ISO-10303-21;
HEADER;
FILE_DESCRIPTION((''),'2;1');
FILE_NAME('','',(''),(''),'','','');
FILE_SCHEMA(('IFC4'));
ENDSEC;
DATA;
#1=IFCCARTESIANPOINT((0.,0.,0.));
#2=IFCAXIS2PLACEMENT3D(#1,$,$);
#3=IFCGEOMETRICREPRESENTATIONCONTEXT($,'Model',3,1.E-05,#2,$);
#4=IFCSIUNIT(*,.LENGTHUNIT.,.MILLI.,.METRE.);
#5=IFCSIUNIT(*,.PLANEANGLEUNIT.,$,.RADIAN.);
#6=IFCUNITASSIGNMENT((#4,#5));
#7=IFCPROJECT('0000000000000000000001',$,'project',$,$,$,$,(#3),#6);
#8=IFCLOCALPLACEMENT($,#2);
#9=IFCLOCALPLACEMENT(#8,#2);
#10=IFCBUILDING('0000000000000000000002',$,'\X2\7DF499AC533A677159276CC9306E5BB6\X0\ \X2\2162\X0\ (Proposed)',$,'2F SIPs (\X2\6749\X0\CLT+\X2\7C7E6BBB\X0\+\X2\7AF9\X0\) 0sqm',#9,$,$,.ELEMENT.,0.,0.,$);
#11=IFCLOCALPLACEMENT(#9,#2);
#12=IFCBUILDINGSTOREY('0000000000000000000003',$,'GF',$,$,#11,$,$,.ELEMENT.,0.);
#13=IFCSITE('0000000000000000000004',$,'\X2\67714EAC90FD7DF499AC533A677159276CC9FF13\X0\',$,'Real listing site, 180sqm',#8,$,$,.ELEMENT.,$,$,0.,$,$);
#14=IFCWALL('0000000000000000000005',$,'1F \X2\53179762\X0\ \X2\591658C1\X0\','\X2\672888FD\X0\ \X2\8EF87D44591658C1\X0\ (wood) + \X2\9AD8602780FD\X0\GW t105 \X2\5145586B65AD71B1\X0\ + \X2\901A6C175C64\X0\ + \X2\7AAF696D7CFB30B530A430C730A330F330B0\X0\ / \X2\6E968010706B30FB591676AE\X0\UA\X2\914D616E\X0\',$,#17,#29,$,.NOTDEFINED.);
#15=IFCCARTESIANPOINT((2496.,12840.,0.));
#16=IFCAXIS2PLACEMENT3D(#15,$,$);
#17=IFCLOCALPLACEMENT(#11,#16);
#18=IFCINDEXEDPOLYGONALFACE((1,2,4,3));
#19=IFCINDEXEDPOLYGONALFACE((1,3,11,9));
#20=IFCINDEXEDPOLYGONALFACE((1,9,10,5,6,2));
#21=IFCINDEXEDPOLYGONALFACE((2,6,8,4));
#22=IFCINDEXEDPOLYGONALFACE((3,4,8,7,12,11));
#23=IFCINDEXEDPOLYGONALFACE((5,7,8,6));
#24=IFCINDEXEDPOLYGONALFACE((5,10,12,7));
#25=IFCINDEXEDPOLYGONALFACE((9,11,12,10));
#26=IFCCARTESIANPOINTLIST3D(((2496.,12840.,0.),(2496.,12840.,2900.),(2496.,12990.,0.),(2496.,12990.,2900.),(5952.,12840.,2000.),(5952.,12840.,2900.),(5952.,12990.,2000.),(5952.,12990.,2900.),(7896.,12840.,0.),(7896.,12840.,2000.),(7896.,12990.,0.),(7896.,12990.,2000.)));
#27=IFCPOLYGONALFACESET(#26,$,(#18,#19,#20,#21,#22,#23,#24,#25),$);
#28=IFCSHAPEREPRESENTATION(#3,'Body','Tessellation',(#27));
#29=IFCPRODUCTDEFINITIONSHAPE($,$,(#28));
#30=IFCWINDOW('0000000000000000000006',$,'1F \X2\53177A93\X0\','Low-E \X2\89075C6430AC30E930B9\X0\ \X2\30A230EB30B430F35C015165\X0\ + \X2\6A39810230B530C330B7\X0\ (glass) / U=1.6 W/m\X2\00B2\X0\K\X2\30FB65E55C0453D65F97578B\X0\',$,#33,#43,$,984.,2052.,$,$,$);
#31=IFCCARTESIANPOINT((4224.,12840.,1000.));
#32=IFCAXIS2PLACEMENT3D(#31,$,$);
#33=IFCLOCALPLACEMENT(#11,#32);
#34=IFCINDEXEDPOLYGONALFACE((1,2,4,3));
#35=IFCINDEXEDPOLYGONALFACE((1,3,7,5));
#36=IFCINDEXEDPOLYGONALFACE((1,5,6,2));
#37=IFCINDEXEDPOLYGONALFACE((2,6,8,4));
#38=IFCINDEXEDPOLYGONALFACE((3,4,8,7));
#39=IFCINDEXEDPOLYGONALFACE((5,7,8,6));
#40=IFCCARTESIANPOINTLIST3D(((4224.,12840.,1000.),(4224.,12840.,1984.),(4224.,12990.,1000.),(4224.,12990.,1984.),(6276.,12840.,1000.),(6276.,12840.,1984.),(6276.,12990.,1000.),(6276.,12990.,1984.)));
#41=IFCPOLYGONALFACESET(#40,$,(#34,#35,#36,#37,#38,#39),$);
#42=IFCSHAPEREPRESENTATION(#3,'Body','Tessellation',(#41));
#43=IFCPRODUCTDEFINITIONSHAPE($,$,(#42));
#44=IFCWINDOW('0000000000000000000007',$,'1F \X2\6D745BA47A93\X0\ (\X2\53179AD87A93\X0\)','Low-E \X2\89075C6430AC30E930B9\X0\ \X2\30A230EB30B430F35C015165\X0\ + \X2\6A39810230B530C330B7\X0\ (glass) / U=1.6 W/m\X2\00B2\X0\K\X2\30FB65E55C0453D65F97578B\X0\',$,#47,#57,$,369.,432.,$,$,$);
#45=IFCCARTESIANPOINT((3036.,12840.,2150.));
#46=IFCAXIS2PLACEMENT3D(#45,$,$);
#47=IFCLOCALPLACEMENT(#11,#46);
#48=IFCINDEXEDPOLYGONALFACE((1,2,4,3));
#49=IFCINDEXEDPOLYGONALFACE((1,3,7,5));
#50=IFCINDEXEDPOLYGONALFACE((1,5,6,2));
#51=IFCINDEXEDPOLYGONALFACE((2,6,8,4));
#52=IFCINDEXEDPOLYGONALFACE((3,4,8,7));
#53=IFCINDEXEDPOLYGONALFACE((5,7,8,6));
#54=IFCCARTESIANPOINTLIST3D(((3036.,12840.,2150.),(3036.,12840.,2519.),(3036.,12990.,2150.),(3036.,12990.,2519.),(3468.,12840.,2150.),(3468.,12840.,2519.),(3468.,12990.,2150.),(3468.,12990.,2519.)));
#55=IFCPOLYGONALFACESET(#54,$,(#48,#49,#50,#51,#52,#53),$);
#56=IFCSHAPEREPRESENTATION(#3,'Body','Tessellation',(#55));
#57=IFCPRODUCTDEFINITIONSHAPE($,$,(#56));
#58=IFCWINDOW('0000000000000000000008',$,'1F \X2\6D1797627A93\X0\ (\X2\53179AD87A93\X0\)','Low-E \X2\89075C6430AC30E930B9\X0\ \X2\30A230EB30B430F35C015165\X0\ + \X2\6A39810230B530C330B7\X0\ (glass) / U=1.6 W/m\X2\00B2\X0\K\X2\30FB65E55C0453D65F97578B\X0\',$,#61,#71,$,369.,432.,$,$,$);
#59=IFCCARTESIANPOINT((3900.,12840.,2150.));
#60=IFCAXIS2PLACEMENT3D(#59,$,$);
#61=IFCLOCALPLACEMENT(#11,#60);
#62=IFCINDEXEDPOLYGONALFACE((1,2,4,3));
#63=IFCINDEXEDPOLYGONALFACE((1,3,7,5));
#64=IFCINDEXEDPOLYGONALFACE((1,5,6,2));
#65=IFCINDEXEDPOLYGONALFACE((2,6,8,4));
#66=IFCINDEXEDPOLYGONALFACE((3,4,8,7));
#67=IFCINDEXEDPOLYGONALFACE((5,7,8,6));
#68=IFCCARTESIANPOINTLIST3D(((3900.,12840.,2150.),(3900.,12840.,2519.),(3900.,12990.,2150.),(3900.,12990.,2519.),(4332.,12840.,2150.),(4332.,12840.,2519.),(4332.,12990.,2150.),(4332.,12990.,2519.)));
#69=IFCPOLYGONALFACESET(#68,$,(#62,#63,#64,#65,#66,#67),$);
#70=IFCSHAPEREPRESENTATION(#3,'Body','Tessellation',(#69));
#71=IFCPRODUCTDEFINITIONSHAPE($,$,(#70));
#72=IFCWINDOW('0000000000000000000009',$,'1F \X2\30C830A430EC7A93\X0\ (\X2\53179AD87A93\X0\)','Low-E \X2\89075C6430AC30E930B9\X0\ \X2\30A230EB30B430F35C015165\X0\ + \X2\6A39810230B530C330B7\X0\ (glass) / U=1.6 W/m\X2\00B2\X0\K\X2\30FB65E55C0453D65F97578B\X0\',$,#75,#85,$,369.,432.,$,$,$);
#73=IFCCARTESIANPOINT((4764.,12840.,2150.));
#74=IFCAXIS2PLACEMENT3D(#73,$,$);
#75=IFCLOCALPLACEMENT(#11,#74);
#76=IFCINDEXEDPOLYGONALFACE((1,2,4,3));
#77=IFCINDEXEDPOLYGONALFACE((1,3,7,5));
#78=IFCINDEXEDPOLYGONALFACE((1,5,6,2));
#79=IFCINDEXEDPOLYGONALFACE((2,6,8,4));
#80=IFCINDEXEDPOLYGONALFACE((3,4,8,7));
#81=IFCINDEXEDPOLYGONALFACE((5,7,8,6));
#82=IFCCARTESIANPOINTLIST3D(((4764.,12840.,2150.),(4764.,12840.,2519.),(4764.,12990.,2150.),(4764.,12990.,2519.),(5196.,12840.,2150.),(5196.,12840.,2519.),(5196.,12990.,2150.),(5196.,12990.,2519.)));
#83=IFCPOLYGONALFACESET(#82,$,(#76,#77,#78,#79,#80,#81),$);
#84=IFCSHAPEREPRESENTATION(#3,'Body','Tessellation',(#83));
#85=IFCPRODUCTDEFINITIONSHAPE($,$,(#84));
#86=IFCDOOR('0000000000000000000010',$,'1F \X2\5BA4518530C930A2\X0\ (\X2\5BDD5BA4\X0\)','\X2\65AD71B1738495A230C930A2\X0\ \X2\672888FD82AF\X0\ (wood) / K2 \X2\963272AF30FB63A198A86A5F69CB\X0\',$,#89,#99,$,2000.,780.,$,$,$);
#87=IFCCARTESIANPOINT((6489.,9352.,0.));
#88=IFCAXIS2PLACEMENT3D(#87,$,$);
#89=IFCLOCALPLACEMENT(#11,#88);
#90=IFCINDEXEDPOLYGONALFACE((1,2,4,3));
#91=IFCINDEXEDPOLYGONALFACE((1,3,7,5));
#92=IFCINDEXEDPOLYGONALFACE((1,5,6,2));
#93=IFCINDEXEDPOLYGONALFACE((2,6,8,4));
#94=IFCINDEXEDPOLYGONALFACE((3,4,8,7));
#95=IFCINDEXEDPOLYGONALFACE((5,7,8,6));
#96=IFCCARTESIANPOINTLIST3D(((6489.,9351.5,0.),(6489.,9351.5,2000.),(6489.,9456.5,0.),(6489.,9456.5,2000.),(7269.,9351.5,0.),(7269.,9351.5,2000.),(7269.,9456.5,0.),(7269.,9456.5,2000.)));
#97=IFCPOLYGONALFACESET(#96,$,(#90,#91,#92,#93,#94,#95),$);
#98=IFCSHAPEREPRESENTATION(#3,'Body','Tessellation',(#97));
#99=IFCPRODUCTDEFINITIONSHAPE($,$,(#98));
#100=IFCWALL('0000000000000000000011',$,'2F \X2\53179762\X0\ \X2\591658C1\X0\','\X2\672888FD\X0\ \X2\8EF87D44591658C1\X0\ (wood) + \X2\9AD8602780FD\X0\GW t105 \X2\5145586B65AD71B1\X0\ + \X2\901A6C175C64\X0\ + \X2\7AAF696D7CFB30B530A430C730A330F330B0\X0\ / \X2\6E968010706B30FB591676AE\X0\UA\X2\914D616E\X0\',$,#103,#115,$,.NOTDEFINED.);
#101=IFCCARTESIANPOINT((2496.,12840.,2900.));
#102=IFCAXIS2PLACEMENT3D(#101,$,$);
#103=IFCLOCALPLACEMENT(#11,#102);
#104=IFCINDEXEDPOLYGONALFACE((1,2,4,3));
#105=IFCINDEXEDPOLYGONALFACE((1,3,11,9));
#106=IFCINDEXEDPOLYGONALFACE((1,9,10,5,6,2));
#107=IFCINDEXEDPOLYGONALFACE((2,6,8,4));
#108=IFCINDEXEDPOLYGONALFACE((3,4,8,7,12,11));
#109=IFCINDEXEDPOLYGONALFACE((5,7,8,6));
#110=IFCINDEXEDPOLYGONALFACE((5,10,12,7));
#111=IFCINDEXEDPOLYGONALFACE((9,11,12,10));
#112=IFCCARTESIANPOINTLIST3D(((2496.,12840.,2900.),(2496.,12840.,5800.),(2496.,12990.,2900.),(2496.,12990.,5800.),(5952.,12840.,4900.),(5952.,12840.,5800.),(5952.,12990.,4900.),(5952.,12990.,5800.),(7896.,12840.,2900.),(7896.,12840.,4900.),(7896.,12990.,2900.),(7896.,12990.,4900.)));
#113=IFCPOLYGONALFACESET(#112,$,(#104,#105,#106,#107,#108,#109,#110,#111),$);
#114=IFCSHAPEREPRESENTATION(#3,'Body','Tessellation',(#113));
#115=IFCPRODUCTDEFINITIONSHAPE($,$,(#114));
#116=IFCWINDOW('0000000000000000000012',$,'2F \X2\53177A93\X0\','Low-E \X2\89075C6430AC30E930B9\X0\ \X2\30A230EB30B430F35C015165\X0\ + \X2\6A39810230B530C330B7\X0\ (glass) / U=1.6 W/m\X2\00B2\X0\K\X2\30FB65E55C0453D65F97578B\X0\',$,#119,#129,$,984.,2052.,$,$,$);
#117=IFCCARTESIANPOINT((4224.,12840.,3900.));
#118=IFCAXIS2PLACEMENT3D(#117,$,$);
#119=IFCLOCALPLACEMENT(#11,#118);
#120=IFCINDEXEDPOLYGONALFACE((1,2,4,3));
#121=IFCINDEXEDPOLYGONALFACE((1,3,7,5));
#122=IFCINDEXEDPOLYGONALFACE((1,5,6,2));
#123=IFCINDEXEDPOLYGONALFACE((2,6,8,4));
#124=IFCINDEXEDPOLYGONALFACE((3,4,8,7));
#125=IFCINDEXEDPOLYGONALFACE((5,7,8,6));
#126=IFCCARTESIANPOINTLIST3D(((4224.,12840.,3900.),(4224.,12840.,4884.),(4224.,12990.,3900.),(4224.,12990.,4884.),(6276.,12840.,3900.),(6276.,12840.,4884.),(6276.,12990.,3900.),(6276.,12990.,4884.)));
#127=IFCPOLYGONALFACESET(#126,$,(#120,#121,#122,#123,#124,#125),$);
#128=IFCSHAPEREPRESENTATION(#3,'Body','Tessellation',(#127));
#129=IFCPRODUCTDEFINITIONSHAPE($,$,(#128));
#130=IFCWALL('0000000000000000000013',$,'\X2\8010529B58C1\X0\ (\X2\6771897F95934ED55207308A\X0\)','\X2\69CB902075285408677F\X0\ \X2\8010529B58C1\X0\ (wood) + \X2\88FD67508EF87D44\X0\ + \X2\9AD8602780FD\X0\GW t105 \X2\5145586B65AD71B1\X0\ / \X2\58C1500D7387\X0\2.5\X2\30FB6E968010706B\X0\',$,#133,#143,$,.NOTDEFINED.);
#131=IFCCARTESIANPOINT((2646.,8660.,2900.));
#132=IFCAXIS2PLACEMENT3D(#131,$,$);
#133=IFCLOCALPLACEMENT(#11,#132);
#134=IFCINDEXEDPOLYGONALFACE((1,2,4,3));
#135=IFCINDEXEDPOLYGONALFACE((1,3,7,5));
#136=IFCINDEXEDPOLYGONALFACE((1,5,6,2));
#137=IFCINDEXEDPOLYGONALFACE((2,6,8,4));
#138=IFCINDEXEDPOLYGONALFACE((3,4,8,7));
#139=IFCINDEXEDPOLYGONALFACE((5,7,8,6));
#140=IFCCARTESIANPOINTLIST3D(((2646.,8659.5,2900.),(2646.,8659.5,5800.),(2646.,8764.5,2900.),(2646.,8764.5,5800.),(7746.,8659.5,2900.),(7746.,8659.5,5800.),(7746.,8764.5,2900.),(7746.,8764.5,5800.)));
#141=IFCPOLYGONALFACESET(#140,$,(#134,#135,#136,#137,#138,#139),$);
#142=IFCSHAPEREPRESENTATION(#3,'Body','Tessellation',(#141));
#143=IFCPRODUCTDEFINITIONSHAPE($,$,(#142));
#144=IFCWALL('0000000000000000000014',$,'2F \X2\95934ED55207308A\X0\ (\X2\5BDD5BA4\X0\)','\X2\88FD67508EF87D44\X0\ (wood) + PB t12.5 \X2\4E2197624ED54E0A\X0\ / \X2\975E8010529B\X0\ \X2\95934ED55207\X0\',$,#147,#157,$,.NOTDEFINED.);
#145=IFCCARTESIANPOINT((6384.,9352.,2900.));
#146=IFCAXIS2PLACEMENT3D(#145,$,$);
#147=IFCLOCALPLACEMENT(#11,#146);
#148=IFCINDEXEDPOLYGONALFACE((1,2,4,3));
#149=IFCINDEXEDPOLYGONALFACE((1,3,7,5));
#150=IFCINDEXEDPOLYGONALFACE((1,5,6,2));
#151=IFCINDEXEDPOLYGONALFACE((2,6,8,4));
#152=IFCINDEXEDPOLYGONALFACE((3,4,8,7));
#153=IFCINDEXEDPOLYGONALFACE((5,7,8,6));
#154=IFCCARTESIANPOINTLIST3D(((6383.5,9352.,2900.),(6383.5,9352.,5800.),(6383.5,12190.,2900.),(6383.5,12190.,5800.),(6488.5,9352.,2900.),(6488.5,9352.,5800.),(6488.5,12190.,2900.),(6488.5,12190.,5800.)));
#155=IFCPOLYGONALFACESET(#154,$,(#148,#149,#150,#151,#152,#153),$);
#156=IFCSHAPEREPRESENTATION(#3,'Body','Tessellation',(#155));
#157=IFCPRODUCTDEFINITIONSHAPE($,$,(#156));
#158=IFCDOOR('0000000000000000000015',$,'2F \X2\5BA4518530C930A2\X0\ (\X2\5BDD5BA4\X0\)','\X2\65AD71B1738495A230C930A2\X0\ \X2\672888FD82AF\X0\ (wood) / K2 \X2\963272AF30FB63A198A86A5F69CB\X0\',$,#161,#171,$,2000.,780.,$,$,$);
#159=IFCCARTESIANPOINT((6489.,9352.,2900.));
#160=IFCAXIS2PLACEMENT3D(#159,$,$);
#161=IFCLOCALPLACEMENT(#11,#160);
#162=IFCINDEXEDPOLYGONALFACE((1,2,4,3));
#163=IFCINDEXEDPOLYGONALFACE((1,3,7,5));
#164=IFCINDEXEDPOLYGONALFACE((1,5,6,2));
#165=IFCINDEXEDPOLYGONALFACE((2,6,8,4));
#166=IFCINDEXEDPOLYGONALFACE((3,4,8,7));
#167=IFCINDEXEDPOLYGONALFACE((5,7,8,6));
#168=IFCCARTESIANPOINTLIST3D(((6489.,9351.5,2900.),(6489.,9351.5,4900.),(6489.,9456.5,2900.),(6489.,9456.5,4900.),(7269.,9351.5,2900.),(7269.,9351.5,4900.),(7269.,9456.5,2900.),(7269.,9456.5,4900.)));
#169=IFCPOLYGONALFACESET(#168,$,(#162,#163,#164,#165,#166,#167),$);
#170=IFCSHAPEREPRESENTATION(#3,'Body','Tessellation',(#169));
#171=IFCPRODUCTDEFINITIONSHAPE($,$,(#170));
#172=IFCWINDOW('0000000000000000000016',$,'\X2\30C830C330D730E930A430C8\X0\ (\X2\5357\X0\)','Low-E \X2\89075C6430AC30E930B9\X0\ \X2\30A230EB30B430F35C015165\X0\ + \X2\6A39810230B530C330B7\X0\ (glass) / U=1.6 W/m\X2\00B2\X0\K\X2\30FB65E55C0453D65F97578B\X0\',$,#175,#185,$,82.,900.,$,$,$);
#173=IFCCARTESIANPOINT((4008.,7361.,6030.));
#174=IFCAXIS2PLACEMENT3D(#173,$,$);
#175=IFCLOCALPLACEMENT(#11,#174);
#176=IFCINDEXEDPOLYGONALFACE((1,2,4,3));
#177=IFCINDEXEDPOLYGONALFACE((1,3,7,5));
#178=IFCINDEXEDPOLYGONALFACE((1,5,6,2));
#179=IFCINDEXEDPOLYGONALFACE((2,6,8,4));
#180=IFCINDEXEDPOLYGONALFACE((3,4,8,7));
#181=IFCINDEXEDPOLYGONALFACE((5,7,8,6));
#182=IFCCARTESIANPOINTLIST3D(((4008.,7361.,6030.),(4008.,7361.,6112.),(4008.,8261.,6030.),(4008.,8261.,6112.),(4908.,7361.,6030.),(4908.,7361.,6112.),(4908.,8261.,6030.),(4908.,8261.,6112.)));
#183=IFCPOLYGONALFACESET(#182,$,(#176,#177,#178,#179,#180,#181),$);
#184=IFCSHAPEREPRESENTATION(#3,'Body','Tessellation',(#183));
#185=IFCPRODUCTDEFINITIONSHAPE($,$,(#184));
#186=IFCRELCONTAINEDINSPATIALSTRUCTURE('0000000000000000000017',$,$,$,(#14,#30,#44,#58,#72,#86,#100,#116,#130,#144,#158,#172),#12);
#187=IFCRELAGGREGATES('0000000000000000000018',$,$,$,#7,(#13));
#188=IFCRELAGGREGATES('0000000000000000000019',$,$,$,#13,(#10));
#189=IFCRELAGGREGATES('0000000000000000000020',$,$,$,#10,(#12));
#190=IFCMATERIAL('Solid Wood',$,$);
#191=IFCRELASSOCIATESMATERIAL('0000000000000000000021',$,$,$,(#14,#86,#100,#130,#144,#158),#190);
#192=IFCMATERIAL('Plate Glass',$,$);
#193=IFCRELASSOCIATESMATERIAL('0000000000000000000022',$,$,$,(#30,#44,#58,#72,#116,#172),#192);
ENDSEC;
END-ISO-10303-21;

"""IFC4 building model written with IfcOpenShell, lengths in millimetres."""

from ifc_helpers import new_model, si_unit, frame, frame_2d, origin, place, context, project, spatial, rectangle, extrude, material, element, fill, save


model = new_model("IFC4")

# Units and contexts
model_context = context("Model", 3, precision=1e-05, world=origin())
ifc_project = project(units=[si_unit("LENGTHUNIT", "METRE", prefix="MILLI"), si_unit("PLANEANGLEUNIT", "RADIAN")], contexts=[model_context])

# Site, building, storey
site_placement = place(None, origin())
site = spatial("IfcSite", under=ifc_project, at=site_placement, Name="東京都練馬区東大泉３", ObjectType="Real listing site, 180sqm", CompositionType="ELEMENT", RefElevation=0.0)
building_placement = place(site_placement, origin())
building = spatial("IfcBuilding", under=site, at=building_placement, Name="練馬区東大泉の家 Ⅲ (Proposed)", ObjectType="2F SIPs (杉CLT+籾殻+竹) 0sqm", CompositionType="ELEMENT", ElevationOfRefHeight=0.0, ElevationOfTerrain=0.0)
storey_placement = place(building_placement, origin())
storey = spatial("IfcBuildingStorey", under=building, at=storey_placement, Name="GF", CompositionType="ELEMENT", Elevation=0.0)

# Wall, openings, windows
ifc_material_1 = material(Name="Solid Wood")
wall_1_placement = place(storey_placement, frame((2496.0, 12840.0, 0.0)))
wall_1 = element("IfcWall", 1, at=wall_1_placement, inside=storey, material=ifc_material_1, Name="1F 北面 外壁", Description="木製 軸組外壁 (wood) + 高性能GW t105 充填断熱 + 通気層 + 窯業系サイディング / 準耐火・外皮UA配慮", PredefinedType="NOTDEFINED", context=model_context, shape_type="SweptSolid", body=[
    extrude(rectangle(XDim=5400.0, YDim=150.0, at=frame_2d((2700.0, 75.0))), frame((2496.0, 12840.0, 0.0)), (0.0, 0.0, 1.0), 2900.0),
])
opening_1_placement = place(storey_placement, frame((4224.0, 12840.0, 1000.0)))
opening_1 = element("IfcOpeningElement", 2, at=opening_1_placement, cuts=wall_1, PredefinedType="NOTDEFINED", context=model_context, shape_type="SweptSolid", body=[
    extrude(rectangle(XDim=2052.0, YDim=150.0, at=frame_2d((1026.0, 75.0))), frame((4224.0, 12840.0, 1000.0)), (0.0, 0.0, 1.0), 984.0),
])
opening_2_placement = place(storey_placement, frame((3036.0, 12840.0, 2150.0)))
opening_2 = element("IfcOpeningElement", 3, at=opening_2_placement, cuts=wall_1, PredefinedType="NOTDEFINED", context=model_context, shape_type="SweptSolid", body=[
    extrude(rectangle(XDim=432.0, YDim=150.0, at=frame_2d((216.0, 75.0))), frame((3036.0, 12840.0, 2150.0)), (0.0, 0.0, 1.0), 369.0),
])
opening_3_placement = place(storey_placement, frame((3900.0, 12840.0, 2150.0)))
opening_3 = element("IfcOpeningElement", 4, at=opening_3_placement, cuts=wall_1, PredefinedType="NOTDEFINED", context=model_context, shape_type="SweptSolid", body=[
    extrude(rectangle(XDim=432.0, YDim=150.0, at=frame_2d((216.0, 75.0))), frame((3900.0, 12840.0, 2150.0)), (0.0, 0.0, 1.0), 369.0),
])
opening_4_placement = place(storey_placement, frame((4764.0, 12840.0, 2150.0)))
opening_4 = element("IfcOpeningElement", 5, at=opening_4_placement, cuts=wall_1, PredefinedType="NOTDEFINED", context=model_context, shape_type="SweptSolid", body=[
    extrude(rectangle(XDim=432.0, YDim=150.0, at=frame_2d((216.0, 75.0))), frame((4764.0, 12840.0, 2150.0)), (0.0, 0.0, 1.0), 369.0),
])
ifc_material_2 = material(Name="Plate Glass")
window_1_placement = place(storey_placement, frame((4224.0, 12840.0, 1000.0)))
window_1 = element("IfcWindow", 6, at=window_1_placement, inside=storey, material=ifc_material_2, Name="1F 北窓", Description="Low-E 複層ガラス アルゴン封入 + 樹脂サッシ (glass) / U=1.6 W/m²K・日射取得型", OverallHeight=984.0, OverallWidth=2052.0, context=model_context, shape_type="SweptSolid", body=[
    extrude(rectangle(XDim=2052.0, YDim=150.0, at=frame_2d((1026.0, 75.0))), frame((4224.0, 12840.0, 1000.0)), (0.0, 0.0, 1.0), 984.0),
])
fill(opening_1, window_1)
window_2_placement = place(storey_placement, frame((3036.0, 12840.0, 2150.0)))
window_2 = element("IfcWindow", 7, at=window_2_placement, inside=storey, material=ifc_material_2, Name="1F 浴室窓 (北高窓)", Description="Low-E 複層ガラス アルゴン封入 + 樹脂サッシ (glass) / U=1.6 W/m²K・日射取得型", OverallHeight=369.0, OverallWidth=432.0, context=model_context, shape_type="SweptSolid", body=[
    extrude(rectangle(XDim=432.0, YDim=150.0, at=frame_2d((216.0, 75.0))), frame((3036.0, 12840.0, 2150.0)), (0.0, 0.0, 1.0), 369.0),
])
fill(opening_2, window_2)
window_3_placement = place(storey_placement, frame((3900.0, 12840.0, 2150.0)))
window_3 = element("IfcWindow", 8, at=window_3_placement, inside=storey, material=ifc_material_2, Name="1F 洗面窓 (北高窓)", Description="Low-E 複層ガラス アルゴン封入 + 樹脂サッシ (glass) / U=1.6 W/m²K・日射取得型", OverallHeight=369.0, OverallWidth=432.0, context=model_context, shape_type="SweptSolid", body=[
    extrude(rectangle(XDim=432.0, YDim=150.0, at=frame_2d((216.0, 75.0))), frame((3900.0, 12840.0, 2150.0)), (0.0, 0.0, 1.0), 369.0),
])
fill(opening_3, window_3)
window_4_placement = place(storey_placement, frame((4764.0, 12840.0, 2150.0)))
window_4 = element("IfcWindow", 9, at=window_4_placement, inside=storey, material=ifc_material_2, Name="1F トイレ窓 (北高窓)", Description="Low-E 複層ガラス アルゴン封入 + 樹脂サッシ (glass) / U=1.6 W/m²K・日射取得型", OverallHeight=369.0, OverallWidth=432.0, context=model_context, shape_type="SweptSolid", body=[
    extrude(rectangle(XDim=432.0, YDim=150.0, at=frame_2d((216.0, 75.0))), frame((4764.0, 12840.0, 2150.0)), (0.0, 0.0, 1.0), 369.0),
])
fill(opening_4, window_4)

# Door
door_1_placement = place(storey_placement, frame((6489.0, 9352.0, 0.0)))
element("IfcDoor", 10, at=door_1_placement, inside=storey, material=ifc_material_1, Name="1F 室内ドア (寝室)", Description="断熱玄関ドア 木製芯 (wood) / K2 防犯・採風機構", OverallHeight=2000.0, OverallWidth=780.0, context=model_context, shape_type="SweptSolid", body=[
    extrude(rectangle(XDim=780.0, YDim=105.0, at=frame_2d((390.0, 52.0))), frame((6489.0, 9352.0, 0.0)), (0.0, 0.0, 1.0), 2000.0),
])

# Wall, opening, window
wall_2_placement = place(storey_placement, frame((2496.0, 12840.0, 2900.0)))
wall_2 = element("IfcWall", 11, at=wall_2_placement, inside=storey, material=ifc_material_1, Name="2F 北面 外壁", Description="木製 軸組外壁 (wood) + 高性能GW t105 充填断熱 + 通気層 + 窯業系サイディング / 準耐火・外皮UA配慮", PredefinedType="NOTDEFINED", context=model_context, shape_type="SweptSolid", body=[
    extrude(rectangle(XDim=5400.0, YDim=150.0, at=frame_2d((2700.0, 75.0))), frame((2496.0, 12840.0, 2900.0)), (0.0, 0.0, 1.0), 2900.0),
])
opening_5_placement = place(storey_placement, frame((4224.0, 12840.0, 3900.0)))
opening_5 = element("IfcOpeningElement", 12, at=opening_5_placement, cuts=wall_2, PredefinedType="NOTDEFINED", context=model_context, shape_type="SweptSolid", body=[
    extrude(rectangle(XDim=2052.0, YDim=150.0, at=frame_2d((1026.0, 75.0))), frame((4224.0, 12840.0, 3900.0)), (0.0, 0.0, 1.0), 984.0),
])
window_5_placement = place(storey_placement, frame((4224.0, 12840.0, 3900.0)))
window_5 = element("IfcWindow", 13, at=window_5_placement, inside=storey, material=ifc_material_2, Name="2F 北窓", Description="Low-E 複層ガラス アルゴン封入 + 樹脂サッシ (glass) / U=1.6 W/m²K・日射取得型", OverallHeight=984.0, OverallWidth=2052.0, context=model_context, shape_type="SweptSolid", body=[
    extrude(rectangle(XDim=2052.0, YDim=150.0, at=frame_2d((1026.0, 75.0))), frame((4224.0, 12840.0, 3900.0)), (0.0, 0.0, 1.0), 984.0),
])
fill(opening_5, window_5)

# Walls
wall_3_placement = place(storey_placement, frame((2646.0, 8660.0, 2900.0)))
element("IfcWall", 14, at=wall_3_placement, inside=storey, material=ifc_material_1, Name="耐力壁 (東西間仕切り)", Description="構造用合板 耐力壁 (wood) + 製材軸組 + 高性能GW t105 充填断熱 / 壁倍率2.5・準耐火", PredefinedType="NOTDEFINED", context=model_context, shape_type="SweptSolid", body=[
    extrude(rectangle(XDim=5100.0, YDim=105.0, at=frame_2d((2550.0, 52.0))), frame((2646.0, 8660.0, 2900.0)), (0.0, 0.0, 1.0), 2900.0),
])
wall_4_placement = place(storey_placement, frame((6384.0, 9352.0, 2900.0)))
element("IfcWall", 15, at=wall_4_placement, inside=storey, material=ifc_material_1, Name="2F 間仕切り (寝室)", Description="製材軸組 (wood) + PB t12.5 両面仕上 / 非耐力 間仕切", PredefinedType="NOTDEFINED", context=model_context, shape_type="SweptSolid", body=[
    extrude(rectangle(XDim=105.0, YDim=2838.0, at=frame_2d((52.0, 1419.0))), frame((6384.0, 9352.0, 2900.0)), (0.0, 0.0, 1.0), 2900.0),
])

# Door
door_2_placement = place(storey_placement, frame((6489.0, 9352.0, 2900.0)))
element("IfcDoor", 16, at=door_2_placement, inside=storey, material=ifc_material_1, Name="2F 室内ドア (寝室)", Description="断熱玄関ドア 木製芯 (wood) / K2 防犯・採風機構", OverallHeight=2000.0, OverallWidth=780.0, context=model_context, shape_type="SweptSolid", body=[
    extrude(rectangle(XDim=780.0, YDim=105.0, at=frame_2d((390.0, 52.0))), frame((6489.0, 9352.0, 2900.0)), (0.0, 0.0, 1.0), 2000.0),
])

# Window
window_6_placement = place(storey_placement, frame((4008.0, 7361.0, 6030.0)))
element("IfcWindow", 17, at=window_6_placement, inside=storey, material=ifc_material_2, Name="トップライト (南)", Description="Low-E 複層ガラス アルゴン封入 + 樹脂サッシ (glass) / U=1.6 W/m²K・日射取得型", OverallHeight=82.0, OverallWidth=900.0, context=model_context, shape_type="SweptSolid", body=[
    extrude(rectangle(XDim=900.0, YDim=900.0, at=frame_2d((450.0, 450.0))), frame((4008.0, 7361.0, 6030.0)), (0.0, 0.0, 1.0), 82.0),
])

save(model, "model.ifc")
